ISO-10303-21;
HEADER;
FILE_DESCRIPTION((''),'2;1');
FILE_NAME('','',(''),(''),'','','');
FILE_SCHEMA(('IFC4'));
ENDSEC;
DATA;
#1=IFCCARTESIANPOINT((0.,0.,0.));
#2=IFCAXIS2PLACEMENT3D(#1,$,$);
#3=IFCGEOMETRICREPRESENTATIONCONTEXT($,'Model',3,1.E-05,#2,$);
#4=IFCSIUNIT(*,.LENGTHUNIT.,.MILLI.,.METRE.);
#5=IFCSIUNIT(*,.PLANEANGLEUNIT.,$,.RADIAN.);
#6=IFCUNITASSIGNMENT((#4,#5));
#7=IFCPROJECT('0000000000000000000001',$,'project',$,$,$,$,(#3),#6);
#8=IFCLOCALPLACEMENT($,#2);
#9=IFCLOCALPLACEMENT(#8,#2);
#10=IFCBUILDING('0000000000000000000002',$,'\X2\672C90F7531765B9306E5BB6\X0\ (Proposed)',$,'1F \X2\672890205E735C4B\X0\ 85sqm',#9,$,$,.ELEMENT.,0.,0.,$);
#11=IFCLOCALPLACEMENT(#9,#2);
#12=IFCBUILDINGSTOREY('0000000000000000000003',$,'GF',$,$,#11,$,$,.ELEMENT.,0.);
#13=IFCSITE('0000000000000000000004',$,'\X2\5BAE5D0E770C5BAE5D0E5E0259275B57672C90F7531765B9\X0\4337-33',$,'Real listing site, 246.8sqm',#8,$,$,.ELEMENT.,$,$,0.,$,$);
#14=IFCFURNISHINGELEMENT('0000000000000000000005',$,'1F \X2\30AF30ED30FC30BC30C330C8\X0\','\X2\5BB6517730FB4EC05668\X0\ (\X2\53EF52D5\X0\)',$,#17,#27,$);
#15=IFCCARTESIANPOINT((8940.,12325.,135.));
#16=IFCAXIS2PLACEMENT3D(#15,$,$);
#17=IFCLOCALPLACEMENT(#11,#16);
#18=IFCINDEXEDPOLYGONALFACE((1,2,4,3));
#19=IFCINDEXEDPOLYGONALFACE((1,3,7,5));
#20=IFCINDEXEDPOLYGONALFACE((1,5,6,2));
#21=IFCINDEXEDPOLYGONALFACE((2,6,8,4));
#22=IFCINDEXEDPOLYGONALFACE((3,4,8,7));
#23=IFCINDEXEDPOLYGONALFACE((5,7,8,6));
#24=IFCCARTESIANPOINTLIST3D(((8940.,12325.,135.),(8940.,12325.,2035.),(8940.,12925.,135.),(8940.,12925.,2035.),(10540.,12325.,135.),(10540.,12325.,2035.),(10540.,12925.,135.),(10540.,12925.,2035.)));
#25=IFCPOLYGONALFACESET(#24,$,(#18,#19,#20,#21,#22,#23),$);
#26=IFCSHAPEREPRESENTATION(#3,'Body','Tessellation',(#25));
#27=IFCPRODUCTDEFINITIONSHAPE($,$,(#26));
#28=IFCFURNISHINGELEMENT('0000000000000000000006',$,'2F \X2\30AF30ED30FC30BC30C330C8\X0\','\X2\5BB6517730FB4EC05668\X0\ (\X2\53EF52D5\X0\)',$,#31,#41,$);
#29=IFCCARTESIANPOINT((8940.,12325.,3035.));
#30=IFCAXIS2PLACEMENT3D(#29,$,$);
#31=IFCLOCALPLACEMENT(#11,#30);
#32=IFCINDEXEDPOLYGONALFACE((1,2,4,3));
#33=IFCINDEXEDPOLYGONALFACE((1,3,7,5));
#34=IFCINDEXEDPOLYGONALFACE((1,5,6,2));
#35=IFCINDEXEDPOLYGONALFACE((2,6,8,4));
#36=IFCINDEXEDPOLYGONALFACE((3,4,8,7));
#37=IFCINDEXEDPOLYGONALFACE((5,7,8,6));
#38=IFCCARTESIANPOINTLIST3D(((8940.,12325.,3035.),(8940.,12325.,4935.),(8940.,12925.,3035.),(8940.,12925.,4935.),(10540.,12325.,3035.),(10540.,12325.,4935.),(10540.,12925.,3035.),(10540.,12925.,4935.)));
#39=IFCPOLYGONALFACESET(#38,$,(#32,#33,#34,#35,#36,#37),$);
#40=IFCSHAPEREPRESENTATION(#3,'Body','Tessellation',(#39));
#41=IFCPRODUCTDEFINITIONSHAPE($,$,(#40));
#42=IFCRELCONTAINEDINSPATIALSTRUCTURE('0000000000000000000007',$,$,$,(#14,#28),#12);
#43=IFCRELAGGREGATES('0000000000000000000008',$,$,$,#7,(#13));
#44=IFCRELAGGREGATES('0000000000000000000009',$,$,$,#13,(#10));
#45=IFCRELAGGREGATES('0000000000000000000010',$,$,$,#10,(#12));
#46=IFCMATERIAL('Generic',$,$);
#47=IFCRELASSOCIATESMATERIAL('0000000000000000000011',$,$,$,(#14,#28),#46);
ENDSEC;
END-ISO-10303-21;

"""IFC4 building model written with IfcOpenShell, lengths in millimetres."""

from ifc_helpers import new_model, si_unit, frame, frame_2d, origin, place, context, project, spatial, rectangle, extrude, material, element, save


model = new_model("IFC4")

# Units and contexts
model_context = context("Model", 3, precision=1e-05, world=origin())
ifc_project = project(units=[si_unit("LENGTHUNIT", "METRE", prefix="MILLI"), si_unit("PLANEANGLEUNIT", "RADIAN")], contexts=[model_context])

# Site, building, storey
site_placement = place(None, origin())
site = spatial("IfcSite", under=ifc_project, at=site_placement, Name="宮崎県宮崎市大字本郷北方4337-33", ObjectType="Real listing site, 246.8sqm", CompositionType="ELEMENT", RefElevation=0.0)
building_placement = place(site_placement, origin())
building = spatial("IfcBuilding", under=site, at=building_placement, Name="本郷北方の家 (Proposed)", ObjectType="1F 木造平屋 85sqm", CompositionType="ELEMENT", ElevationOfRefHeight=0.0, ElevationOfTerrain=0.0)
storey_placement = place(building_placement, origin())
storey = spatial("IfcBuildingStorey", under=building, at=storey_placement, Name="GF", CompositionType="ELEMENT", Elevation=0.0)

# Shared definitions
ifc_material_1 = material(Name="Generic")

# Furnishing elements
furnishing_1_placement = place(storey_placement, frame((8940.0, 12325.0, 135.0)))
element("IfcFurnishingElement", 1, at=furnishing_1_placement, inside=storey, material=ifc_material_1, Name="1F クローゼット", Description="家具・什器 (可動)", context=model_context, shape_type="SweptSolid", body=[
    extrude(rectangle(XDim=1600.0, YDim=600.0, at=frame_2d((800.0, 300.0))), frame((8940.0, 12325.0, 135.0)), (0.0, 0.0, 1.0), 1900.0),
])
furnishing_2_placement = place(storey_placement, frame((8940.0, 12325.0, 3035.0)))
element("IfcFurnishingElement", 2, at=furnishing_2_placement, inside=storey, material=ifc_material_1, Name="2F クローゼット", Description="家具・什器 (可動)", context=model_context, shape_type="SweptSolid", body=[
    extrude(rectangle(XDim=1600.0, YDim=600.0, at=frame_2d((800.0, 300.0))), frame((8940.0, 12325.0, 3035.0)), (0.0, 0.0, 1.0), 1900.0),
])

save(model, "model.ifc")
